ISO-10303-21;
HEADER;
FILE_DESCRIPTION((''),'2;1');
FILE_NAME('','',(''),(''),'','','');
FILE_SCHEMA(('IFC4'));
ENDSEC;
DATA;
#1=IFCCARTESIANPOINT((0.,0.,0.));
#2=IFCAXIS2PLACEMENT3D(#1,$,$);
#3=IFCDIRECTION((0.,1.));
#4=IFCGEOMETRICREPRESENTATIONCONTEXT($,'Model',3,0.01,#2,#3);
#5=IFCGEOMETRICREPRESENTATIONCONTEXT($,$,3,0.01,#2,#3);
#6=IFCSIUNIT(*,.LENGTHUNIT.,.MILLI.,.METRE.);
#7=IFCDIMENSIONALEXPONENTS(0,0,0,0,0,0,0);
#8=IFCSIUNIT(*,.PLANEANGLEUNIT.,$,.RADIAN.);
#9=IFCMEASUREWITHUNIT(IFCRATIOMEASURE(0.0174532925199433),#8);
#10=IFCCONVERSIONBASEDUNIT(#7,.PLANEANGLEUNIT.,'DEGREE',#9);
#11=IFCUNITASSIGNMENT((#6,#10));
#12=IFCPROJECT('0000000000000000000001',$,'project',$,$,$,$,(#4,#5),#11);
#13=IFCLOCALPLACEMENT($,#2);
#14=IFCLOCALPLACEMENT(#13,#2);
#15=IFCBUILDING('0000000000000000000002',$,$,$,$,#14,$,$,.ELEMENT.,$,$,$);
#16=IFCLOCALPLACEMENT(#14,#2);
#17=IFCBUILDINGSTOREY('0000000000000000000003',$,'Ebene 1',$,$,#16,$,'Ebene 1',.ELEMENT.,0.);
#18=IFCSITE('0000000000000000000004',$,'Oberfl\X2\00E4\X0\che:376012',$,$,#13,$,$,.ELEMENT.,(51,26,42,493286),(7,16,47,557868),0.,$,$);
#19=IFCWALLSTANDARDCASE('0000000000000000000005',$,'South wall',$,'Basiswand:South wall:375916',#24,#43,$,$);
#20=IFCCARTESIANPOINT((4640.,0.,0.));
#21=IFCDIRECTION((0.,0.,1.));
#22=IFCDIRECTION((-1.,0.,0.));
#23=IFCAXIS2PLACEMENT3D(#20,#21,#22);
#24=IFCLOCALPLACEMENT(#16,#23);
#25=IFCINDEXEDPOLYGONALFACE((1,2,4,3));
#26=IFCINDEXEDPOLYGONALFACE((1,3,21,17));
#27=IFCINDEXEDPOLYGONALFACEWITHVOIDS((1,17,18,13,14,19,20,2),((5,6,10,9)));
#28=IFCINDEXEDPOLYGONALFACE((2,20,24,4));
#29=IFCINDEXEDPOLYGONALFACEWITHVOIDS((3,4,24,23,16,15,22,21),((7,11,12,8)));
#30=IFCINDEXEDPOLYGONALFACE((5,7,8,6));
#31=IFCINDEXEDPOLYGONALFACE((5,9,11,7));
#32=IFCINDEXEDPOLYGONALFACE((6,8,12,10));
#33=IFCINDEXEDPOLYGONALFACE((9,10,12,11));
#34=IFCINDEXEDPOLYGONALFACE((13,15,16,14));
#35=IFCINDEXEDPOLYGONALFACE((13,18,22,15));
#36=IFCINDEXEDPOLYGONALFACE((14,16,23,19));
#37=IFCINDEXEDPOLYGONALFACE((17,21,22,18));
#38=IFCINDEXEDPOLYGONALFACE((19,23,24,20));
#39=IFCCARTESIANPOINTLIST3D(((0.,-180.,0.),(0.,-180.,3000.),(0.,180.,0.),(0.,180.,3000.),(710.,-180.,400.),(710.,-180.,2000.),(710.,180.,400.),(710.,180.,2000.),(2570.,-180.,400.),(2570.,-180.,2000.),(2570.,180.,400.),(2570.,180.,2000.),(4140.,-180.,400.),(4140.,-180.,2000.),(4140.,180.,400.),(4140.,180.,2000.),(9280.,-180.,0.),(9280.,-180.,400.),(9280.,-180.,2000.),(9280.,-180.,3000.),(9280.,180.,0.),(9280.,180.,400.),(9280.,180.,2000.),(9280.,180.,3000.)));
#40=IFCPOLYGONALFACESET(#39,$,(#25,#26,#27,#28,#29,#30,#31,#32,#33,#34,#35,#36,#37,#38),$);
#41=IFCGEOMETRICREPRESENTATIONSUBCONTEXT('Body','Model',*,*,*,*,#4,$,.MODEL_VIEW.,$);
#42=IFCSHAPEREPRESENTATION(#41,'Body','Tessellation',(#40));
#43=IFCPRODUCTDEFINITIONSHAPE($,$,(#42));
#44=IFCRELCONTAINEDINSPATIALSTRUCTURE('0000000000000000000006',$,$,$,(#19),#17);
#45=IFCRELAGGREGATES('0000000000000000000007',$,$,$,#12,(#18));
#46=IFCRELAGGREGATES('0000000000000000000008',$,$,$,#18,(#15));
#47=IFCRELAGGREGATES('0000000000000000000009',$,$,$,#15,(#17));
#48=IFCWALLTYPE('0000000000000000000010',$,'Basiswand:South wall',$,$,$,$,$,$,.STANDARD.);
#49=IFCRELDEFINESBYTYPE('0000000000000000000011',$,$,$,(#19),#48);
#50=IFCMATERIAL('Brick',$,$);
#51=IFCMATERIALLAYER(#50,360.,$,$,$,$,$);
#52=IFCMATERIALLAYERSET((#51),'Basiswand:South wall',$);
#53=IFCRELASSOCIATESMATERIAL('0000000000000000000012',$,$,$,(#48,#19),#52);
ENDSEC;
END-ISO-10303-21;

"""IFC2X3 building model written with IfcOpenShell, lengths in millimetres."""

from ifc_helpers import new_model, entity, si_unit, converted_unit, direction, frame, frame_2d, origin, place, context, subcontext, project, spatial, rectangle, extrude, material, layer, layer_set, layer_usage, type_object, element, save


model = new_model("IFC2X3")

# Units and contexts
model_context = context("Model", 3, precision=0.01, world=origin(), true_north=direction((0.0, 1.0)))
context_of_model = context(None, 3, precision=0.01, world=origin(), true_north=direction((0.0, 1.0)))
body_context = subcontext(model_context, "Body", "Model", "MODEL_VIEW")
ifc_project = project(units=[si_unit("LENGTHUNIT", "METRE", prefix="MILLI"), converted_unit("PLANEANGLEUNIT", "DEGREE", entity("IfcRatioMeasure", 0.0174532925199433), si_unit("PLANEANGLEUNIT", "RADIAN"), dimensions=[0, 0, 0, 0, 0, 0, 0])], contexts=[model_context, context_of_model])

# Site, building, storey
site_placement = place(None, origin())
site = spatial("IfcSite", under=ifc_project, at=site_placement, Name="Oberfläche:376012", CompositionType="ELEMENT", RefLatitude=(51, 26, 42, 493286), RefLongitude=(7, 16, 47, 557868), RefElevation=0.0)
building_placement = place(site_placement, origin())
building = spatial("IfcBuilding", under=site, at=building_placement, CompositionType="ELEMENT")
storey_placement = place(building_placement, origin())
storey = spatial("IfcBuildingStorey", under=building, at=storey_placement, Name="Ebene 1", LongName="Ebene 1", CompositionType="ELEMENT", Elevation=0.0)

# Shared definitions
ifc_material_1 = material(Name="Brick")
ifc_layer = layer(ifc_material_1, 360.0)
ifc_layer_set = layer_set([ifc_layer], Name="Basiswand:South wall")
wall_type = type_object("IfcWallType", Name="Basiswand:South wall", PredefinedType="STANDARD", material=ifc_layer_set)

# Wall, opening
ifc_layer_usage_1 = layer_usage(ifc_layer_set, "AXIS2", "NEGATIVE", 180.0)
wall_1_placement = place(storey_placement, frame((4640.0, 0.0, 0.0), z_axis=(0.0, 0.0, 1.0), x_axis=(-1.0, 0.0, 0.0)))
wall_1 = element("IfcWallStandardCase", 1, at=wall_1_placement, inside=storey, type_object=wall_type, material=ifc_layer_usage_1, Name="South wall", ObjectType="Basiswand:South wall:375916", context=body_context, shape_type="SweptSolid", body=[
    extrude(rectangle(XDim=9280.0, YDim=360.0, at=frame_2d((4640.0, 0.0), x_axis=(-1.0, 0.0))), origin(), (0.0, 0.0, 1.0), 3000.0),
])
opening_1_placement = place(wall_1_placement, origin())
element("IfcOpeningElement", 2, at=opening_1_placement, cuts=wall_1, ObjectType="Opening", context=body_context, shape_type="SweptSolid", body=[
    extrude(rectangle(XDim=1600.0, YDim=6000.0, at=frame_2d((0.0, 0.0), x_axis=(0.0, 1.0))), frame((7140.0, -1815.0, 1200.0), z_axis=(0.0, 1.0, 0.0), x_axis=(1.0, 0.0, 0.0)), (0.0, 0.0, 1.0), 3630.0),
    extrude(rectangle(XDim=1600.0, YDim=1860.0, at=frame_2d((0.0, 0.0), x_axis=(0.0, 1.0))), frame((1640.0, -1500.0, 1200.0), z_axis=(0.0, 1.0, 0.0), x_axis=(1.0, 0.0, 0.0)), (0.0, 0.0, 1.0), 3000.0),
])

save(model, "model.ifc")
